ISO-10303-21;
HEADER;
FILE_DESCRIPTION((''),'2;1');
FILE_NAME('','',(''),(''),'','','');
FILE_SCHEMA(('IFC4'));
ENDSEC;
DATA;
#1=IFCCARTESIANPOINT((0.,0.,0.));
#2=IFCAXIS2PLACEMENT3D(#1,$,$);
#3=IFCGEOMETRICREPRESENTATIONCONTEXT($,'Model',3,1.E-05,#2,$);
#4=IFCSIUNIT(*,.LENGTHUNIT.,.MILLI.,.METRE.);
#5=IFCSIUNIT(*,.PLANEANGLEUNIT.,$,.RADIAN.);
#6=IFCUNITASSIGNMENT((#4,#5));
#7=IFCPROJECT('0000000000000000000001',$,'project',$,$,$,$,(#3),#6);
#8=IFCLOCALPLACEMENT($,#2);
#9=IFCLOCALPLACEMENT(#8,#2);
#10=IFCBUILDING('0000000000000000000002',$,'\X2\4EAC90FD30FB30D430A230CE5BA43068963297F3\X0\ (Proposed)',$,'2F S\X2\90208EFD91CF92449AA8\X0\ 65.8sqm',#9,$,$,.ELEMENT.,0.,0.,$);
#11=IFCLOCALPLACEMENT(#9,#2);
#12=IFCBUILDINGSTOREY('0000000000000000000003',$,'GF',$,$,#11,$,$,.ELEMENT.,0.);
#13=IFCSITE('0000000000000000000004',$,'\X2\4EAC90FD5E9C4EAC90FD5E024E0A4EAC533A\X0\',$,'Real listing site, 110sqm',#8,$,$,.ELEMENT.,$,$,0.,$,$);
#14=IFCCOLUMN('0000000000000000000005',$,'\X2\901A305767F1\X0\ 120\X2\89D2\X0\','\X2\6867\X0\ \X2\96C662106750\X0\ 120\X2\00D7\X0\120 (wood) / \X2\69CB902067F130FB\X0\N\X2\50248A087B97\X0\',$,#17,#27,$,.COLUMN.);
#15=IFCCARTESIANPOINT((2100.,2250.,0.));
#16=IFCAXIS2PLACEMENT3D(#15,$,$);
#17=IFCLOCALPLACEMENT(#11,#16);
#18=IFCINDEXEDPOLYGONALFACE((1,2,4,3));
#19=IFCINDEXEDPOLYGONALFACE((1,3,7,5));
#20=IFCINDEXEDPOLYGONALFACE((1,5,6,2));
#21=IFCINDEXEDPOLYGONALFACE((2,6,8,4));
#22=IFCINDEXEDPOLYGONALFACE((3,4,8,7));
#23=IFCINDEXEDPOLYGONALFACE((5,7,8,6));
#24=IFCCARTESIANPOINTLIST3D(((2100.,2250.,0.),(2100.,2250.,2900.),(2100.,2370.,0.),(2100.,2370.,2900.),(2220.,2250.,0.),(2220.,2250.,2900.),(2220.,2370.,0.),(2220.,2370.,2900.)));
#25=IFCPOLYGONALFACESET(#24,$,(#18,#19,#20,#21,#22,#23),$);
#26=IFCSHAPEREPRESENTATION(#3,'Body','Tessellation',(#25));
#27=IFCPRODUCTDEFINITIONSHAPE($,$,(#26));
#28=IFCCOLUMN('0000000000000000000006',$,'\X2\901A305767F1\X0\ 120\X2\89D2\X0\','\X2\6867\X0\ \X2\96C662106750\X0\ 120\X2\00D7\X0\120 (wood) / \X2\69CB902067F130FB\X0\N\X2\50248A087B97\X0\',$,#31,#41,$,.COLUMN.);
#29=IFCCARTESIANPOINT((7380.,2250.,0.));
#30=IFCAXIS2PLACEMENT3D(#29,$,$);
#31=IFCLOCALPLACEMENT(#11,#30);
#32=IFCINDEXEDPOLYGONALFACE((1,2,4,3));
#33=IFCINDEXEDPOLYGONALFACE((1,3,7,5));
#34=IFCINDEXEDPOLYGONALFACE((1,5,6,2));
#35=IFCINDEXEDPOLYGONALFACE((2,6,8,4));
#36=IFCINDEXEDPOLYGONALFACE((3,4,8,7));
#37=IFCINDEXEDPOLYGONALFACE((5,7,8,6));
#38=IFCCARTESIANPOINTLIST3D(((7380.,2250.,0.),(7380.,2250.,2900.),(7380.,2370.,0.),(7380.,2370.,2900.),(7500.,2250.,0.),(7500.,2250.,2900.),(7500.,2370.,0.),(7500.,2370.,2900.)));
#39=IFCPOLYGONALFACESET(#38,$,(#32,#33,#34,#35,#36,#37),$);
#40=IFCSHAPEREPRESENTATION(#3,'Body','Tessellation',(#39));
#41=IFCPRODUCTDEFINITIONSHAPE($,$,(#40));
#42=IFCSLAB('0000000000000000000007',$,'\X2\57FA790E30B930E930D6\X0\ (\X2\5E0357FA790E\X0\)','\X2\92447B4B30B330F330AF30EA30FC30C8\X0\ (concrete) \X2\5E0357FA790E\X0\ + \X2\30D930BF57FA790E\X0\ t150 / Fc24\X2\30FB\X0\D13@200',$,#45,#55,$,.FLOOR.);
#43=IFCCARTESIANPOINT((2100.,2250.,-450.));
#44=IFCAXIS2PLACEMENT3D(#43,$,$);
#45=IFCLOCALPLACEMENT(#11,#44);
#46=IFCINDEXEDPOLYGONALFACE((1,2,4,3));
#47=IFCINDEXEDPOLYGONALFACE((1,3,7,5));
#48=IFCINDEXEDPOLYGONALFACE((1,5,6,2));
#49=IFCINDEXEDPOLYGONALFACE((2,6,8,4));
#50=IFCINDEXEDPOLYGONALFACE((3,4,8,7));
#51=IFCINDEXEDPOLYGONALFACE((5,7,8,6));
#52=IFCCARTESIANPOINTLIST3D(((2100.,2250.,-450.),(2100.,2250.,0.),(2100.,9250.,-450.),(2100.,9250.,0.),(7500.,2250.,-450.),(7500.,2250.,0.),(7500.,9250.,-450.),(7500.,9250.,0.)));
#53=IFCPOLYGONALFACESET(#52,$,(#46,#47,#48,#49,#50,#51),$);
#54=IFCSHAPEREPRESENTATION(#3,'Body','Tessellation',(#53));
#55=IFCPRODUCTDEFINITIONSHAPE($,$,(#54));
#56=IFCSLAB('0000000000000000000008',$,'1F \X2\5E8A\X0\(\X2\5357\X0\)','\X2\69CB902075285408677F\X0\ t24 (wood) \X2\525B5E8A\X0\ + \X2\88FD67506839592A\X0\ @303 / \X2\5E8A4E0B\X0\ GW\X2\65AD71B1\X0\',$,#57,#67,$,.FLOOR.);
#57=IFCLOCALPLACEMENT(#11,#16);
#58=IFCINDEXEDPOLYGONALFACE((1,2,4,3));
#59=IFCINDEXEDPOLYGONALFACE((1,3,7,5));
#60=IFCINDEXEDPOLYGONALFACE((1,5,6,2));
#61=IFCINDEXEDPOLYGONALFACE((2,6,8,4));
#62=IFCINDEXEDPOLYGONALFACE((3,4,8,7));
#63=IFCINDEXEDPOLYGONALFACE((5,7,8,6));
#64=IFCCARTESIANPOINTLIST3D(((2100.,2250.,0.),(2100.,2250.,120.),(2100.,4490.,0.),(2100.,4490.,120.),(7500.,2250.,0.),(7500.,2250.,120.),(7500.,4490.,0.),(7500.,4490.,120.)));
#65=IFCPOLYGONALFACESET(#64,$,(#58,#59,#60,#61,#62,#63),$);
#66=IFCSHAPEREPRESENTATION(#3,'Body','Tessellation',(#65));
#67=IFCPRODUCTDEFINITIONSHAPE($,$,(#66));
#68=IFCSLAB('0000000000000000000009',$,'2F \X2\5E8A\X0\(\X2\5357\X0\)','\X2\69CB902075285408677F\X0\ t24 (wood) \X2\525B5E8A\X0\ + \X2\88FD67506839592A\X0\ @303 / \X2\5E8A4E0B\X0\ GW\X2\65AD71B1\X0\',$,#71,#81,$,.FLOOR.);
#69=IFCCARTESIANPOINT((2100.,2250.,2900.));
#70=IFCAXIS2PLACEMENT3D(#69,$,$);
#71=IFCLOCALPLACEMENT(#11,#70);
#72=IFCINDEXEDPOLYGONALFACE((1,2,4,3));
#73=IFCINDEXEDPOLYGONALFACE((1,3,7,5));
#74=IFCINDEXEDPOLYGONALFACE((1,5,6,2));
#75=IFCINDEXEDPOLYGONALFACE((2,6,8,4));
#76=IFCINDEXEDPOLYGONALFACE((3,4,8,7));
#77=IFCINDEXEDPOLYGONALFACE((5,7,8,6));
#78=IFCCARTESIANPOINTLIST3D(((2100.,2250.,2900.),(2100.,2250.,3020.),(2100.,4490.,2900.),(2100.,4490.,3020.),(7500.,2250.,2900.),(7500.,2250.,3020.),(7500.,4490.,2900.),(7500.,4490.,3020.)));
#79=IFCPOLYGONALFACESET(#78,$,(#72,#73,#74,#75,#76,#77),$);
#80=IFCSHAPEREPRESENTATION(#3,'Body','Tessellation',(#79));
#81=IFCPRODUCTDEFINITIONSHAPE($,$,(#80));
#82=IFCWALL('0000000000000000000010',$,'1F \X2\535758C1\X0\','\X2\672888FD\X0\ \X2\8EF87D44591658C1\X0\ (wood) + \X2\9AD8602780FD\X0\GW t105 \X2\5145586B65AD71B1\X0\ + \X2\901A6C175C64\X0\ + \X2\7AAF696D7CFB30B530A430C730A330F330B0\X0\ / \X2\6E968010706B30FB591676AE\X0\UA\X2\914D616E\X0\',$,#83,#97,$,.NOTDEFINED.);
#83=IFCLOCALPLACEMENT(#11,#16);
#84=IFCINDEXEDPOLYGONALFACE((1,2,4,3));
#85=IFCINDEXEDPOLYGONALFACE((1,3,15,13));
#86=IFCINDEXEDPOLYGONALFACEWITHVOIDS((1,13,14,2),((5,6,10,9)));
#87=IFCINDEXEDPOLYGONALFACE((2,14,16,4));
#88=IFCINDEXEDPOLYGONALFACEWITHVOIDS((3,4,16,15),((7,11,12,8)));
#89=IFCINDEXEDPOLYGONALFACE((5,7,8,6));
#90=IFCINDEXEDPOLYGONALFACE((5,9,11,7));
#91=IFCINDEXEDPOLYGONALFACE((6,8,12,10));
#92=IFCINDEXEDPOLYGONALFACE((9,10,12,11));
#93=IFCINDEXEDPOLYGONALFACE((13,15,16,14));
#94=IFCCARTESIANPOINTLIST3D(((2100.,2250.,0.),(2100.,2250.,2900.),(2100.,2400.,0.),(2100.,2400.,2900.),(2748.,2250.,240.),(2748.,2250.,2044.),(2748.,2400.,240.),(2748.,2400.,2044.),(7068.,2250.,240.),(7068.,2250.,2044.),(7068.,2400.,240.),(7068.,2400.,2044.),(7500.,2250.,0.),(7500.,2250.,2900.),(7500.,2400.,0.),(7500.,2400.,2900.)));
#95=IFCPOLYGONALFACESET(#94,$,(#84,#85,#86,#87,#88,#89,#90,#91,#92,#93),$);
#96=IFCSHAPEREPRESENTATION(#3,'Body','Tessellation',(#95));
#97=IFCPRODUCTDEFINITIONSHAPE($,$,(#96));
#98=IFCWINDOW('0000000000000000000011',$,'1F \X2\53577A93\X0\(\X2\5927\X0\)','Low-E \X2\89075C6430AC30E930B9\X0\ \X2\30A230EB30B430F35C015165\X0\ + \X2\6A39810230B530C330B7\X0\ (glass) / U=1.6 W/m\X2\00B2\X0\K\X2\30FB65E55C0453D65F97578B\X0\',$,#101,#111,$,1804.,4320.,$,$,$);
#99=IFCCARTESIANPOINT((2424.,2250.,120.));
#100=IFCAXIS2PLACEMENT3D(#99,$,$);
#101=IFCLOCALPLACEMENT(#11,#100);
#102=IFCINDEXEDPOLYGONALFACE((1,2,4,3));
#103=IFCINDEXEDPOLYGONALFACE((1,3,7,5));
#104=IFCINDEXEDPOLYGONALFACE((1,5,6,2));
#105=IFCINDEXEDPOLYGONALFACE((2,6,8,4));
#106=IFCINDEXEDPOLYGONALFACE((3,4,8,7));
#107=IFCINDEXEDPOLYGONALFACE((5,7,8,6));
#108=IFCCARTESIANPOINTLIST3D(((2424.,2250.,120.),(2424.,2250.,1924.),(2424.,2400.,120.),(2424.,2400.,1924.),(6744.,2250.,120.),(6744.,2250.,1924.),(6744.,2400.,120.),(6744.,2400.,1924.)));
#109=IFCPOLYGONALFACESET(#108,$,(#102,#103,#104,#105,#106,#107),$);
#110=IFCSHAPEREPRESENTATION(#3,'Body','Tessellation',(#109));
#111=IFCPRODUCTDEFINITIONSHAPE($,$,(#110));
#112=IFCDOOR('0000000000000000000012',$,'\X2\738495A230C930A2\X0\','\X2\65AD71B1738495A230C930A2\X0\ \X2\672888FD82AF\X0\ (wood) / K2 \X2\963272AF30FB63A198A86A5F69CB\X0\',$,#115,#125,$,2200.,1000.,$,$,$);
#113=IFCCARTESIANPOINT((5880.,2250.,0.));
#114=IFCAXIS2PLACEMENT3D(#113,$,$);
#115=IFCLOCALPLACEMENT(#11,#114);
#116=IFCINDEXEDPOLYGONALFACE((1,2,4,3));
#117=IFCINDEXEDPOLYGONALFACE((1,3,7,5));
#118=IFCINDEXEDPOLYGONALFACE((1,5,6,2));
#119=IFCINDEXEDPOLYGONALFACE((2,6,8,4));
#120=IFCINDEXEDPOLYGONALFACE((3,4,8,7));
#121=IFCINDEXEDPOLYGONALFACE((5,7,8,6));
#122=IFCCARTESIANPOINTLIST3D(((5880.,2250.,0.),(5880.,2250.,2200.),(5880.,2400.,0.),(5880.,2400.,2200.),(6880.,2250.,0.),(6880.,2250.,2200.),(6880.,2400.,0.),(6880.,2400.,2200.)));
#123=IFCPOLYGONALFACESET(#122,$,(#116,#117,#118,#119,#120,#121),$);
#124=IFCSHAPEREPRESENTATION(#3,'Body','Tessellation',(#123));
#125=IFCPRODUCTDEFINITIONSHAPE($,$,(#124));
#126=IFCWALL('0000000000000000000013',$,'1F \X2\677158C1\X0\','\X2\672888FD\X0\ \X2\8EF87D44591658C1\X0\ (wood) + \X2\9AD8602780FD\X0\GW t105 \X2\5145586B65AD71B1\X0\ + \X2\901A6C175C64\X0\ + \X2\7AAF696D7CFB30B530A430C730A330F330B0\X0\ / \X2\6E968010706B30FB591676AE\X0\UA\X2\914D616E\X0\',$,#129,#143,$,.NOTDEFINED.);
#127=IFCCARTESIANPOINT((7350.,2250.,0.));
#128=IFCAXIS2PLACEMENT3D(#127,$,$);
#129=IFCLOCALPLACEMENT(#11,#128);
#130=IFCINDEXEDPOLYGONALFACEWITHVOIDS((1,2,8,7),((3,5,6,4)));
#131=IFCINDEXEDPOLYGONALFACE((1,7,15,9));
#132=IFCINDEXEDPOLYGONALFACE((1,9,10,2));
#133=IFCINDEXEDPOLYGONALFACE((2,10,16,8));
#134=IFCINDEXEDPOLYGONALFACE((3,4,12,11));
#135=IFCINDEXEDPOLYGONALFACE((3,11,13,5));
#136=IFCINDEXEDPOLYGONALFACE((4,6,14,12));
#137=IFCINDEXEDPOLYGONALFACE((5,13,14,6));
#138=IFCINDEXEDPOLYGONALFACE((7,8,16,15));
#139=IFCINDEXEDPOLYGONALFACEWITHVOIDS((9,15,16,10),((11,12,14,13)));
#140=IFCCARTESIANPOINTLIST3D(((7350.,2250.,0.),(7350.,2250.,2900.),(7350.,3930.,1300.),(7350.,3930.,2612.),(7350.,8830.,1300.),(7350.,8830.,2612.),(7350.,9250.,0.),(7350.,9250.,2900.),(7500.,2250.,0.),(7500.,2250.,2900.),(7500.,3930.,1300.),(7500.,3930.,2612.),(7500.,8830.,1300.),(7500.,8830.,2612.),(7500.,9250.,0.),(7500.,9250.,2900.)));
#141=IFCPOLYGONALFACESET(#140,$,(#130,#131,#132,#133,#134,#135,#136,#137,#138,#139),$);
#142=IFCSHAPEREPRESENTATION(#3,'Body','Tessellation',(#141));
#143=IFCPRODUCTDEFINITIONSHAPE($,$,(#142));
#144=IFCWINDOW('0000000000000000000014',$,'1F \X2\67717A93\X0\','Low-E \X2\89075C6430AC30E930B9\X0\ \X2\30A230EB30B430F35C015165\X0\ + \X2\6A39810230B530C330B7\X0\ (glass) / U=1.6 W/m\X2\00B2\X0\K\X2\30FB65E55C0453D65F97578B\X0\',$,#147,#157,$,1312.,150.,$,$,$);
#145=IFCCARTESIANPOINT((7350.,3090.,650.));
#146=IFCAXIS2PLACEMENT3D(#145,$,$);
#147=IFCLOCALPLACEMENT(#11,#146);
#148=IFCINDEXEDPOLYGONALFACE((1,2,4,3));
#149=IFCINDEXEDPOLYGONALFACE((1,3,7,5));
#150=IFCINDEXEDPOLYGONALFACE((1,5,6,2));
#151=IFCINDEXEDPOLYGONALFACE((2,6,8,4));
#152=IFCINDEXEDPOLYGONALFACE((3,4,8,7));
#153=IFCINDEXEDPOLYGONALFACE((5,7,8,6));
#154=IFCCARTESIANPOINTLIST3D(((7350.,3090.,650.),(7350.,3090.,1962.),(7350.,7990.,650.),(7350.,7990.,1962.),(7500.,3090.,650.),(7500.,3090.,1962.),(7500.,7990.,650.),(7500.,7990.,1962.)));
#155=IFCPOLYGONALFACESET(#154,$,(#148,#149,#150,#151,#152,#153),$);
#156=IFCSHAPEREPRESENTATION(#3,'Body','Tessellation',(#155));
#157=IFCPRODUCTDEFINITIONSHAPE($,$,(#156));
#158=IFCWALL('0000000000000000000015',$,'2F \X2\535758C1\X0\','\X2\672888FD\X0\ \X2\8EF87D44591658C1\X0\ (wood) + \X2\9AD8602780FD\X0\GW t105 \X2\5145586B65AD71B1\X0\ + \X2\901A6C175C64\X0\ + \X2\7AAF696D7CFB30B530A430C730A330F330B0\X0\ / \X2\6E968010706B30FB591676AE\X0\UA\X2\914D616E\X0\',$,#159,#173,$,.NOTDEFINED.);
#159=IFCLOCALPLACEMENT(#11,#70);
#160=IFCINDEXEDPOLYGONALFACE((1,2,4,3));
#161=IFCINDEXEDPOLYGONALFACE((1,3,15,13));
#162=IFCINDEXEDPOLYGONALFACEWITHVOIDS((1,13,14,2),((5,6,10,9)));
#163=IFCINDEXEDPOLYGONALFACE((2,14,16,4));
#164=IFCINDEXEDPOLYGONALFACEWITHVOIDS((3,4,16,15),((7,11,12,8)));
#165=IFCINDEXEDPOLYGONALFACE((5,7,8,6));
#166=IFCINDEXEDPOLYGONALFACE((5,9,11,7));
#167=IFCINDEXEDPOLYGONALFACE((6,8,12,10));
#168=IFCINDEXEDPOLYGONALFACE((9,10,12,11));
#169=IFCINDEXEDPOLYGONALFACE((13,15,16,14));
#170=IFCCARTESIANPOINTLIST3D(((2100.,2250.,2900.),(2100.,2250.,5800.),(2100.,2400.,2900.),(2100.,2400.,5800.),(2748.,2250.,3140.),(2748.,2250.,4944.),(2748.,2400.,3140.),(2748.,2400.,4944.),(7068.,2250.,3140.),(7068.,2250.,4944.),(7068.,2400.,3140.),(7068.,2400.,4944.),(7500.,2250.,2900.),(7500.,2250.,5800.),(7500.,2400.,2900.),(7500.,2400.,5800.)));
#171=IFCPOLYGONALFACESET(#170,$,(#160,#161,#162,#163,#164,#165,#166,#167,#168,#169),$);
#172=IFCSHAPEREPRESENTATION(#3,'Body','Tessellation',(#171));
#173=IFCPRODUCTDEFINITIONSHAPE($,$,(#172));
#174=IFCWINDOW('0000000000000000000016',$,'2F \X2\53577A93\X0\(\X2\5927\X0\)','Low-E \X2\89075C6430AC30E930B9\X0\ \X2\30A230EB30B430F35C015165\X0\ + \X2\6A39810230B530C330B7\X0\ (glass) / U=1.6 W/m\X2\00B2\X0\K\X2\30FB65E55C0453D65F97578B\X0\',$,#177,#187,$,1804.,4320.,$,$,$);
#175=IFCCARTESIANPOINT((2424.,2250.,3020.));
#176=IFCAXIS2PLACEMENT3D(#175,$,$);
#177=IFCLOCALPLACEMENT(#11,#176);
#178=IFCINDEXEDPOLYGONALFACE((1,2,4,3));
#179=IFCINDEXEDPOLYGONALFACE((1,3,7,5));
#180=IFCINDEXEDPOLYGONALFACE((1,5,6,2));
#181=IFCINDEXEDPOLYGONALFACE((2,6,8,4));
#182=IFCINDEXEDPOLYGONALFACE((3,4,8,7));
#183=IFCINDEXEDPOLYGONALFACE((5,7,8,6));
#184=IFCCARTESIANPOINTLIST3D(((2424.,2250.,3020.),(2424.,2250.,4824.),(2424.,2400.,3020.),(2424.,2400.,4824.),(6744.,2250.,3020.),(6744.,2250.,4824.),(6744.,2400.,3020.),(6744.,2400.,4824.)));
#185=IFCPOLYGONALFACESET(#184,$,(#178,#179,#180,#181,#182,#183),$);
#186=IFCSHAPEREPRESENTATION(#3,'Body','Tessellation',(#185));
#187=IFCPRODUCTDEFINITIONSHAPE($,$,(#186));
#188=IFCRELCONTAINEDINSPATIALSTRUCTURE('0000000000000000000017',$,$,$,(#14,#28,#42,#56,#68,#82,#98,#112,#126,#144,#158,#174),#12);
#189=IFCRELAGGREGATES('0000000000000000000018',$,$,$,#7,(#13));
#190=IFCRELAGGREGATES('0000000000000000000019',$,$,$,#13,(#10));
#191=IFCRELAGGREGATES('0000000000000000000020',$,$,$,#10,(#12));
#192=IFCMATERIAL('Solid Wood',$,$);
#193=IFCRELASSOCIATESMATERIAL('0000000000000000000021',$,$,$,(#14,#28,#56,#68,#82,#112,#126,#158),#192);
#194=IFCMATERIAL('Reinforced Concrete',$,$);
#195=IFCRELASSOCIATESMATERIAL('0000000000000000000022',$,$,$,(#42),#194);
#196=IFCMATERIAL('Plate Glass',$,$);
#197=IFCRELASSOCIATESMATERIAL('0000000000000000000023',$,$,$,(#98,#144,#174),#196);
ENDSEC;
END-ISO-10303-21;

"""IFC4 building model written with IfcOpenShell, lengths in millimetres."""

from ifc_helpers import new_model, si_unit, frame, frame_2d, origin, place, context, project, spatial, rectangle, extrude, material, element, fill, save


model = new_model("IFC4")

# Units and contexts
model_context = context("Model", 3, precision=1e-05, world=origin())
ifc_project = project(units=[si_unit("LENGTHUNIT", "METRE", prefix="MILLI"), si_unit("PLANEANGLEUNIT", "RADIAN")], contexts=[model_context])

# Site, building, storey
site_placement = place(None, origin())
site = spatial("IfcSite", under=ifc_project, at=site_placement, Name="京都府京都市上京区", ObjectType="Real listing site, 110sqm", CompositionType="ELEMENT", RefElevation=0.0)
building_placement = place(site_placement, origin())
building = spatial("IfcBuilding", under=site, at=building_placement, Name="京都・ピアノ室と防音 (Proposed)", ObjectType="2F S造軽量鉄骨 65.8sqm", CompositionType="ELEMENT", ElevationOfRefHeight=0.0, ElevationOfTerrain=0.0)
storey_placement = place(building_placement, origin())
storey = spatial("IfcBuildingStorey", under=building, at=storey_placement, Name="GF", CompositionType="ELEMENT", Elevation=0.0)

# Columns
ifc_material_1 = material(Name="Solid Wood")
column_1_placement = place(storey_placement, frame((2100.0, 2250.0, 0.0)))
element("IfcColumn", 1, at=column_1_placement, inside=storey, material=ifc_material_1, Name="通し柱 120角", Description="桧 集成材 120×120 (wood) / 構造柱・N値計算", PredefinedType="COLUMN", context=model_context, shape_type="SweptSolid", body=[
    extrude(rectangle(XDim=120.0, YDim=120.0, at=frame_2d((60.0, 60.0))), frame((2100.0, 2250.0, 0.0)), (0.0, 0.0, 1.0), 2900.0),
])
column_2_placement = place(storey_placement, frame((7380.0, 2250.0, 0.0)))
element("IfcColumn", 2, at=column_2_placement, inside=storey, material=ifc_material_1, Name="通し柱 120角", Description="桧 集成材 120×120 (wood) / 構造柱・N値計算", PredefinedType="COLUMN", context=model_context, shape_type="SweptSolid", body=[
    extrude(rectangle(XDim=120.0, YDim=120.0, at=frame_2d((60.0, 60.0))), frame((7380.0, 2250.0, 0.0)), (0.0, 0.0, 1.0), 2900.0),
])

# Slabs
ifc_material_2 = material(Name="Reinforced Concrete")
slab_1_placement = place(storey_placement, frame((2100.0, 2250.0, -450.0)))
element("IfcSlab", 3, at=slab_1_placement, inside=storey, material=ifc_material_2, Name="基礎スラブ (布基礎)", Description="鉄筋コンクリート (concrete) 布基礎 + ベタ基礎 t150 / Fc24・D13@200", PredefinedType="FLOOR", context=model_context, shape_type="SweptSolid", body=[
    extrude(rectangle(XDim=5400.0, YDim=7000.0, at=frame_2d((2700.0, 3500.0))), frame((2100.0, 2250.0, -450.0)), (0.0, 0.0, 1.0), 450.0),
])
slab_2_placement = place(storey_placement, frame((2100.0, 2250.0, 0.0)))
element("IfcSlab", 4, at=slab_2_placement, inside=storey, material=ifc_material_1, Name="1F 床(南)", Description="構造用合板 t24 (wood) 剛床 + 製材根太 @303 / 床下 GW断熱", PredefinedType="FLOOR", context=model_context, shape_type="SweptSolid", body=[
    extrude(rectangle(XDim=5400.0, YDim=2240.0, at=frame_2d((2700.0, 1120.0))), frame((2100.0, 2250.0, 0.0)), (0.0, 0.0, 1.0), 120.0),
])
slab_3_placement = place(storey_placement, frame((2100.0, 2250.0, 2900.0)))
element("IfcSlab", 5, at=slab_3_placement, inside=storey, material=ifc_material_1, Name="2F 床(南)", Description="構造用合板 t24 (wood) 剛床 + 製材根太 @303 / 床下 GW断熱", PredefinedType="FLOOR", context=model_context, shape_type="SweptSolid", body=[
    extrude(rectangle(XDim=5400.0, YDim=2240.0, at=frame_2d((2700.0, 1120.0))), frame((2100.0, 2250.0, 2900.0)), (0.0, 0.0, 1.0), 120.0),
])

# Wall, openings, window, door
wall_1_placement = place(storey_placement, frame((2100.0, 2250.0, 0.0)))
wall_1 = element("IfcWall", 6, at=wall_1_placement, inside=storey, material=ifc_material_1, Name="1F 南壁", Description="木製 軸組外壁 (wood) + 高性能GW t105 充填断熱 + 通気層 + 窯業系サイディング / 準耐火・外皮UA配慮", PredefinedType="NOTDEFINED", context=model_context, shape_type="SweptSolid", body=[
    extrude(rectangle(XDim=5400.0, YDim=150.0, at=frame_2d((2700.0, 75.0))), frame((2100.0, 2250.0, 0.0)), (0.0, 0.0, 1.0), 2900.0),
])
opening_1_placement = place(storey_placement, frame((2424.0, 2250.0, 120.0)))
opening_1 = element("IfcOpeningElement", 7, at=opening_1_placement, cuts=wall_1, PredefinedType="NOTDEFINED", context=model_context, shape_type="SweptSolid", body=[
    extrude(rectangle(XDim=4320.0, YDim=150.0, at=frame_2d((2160.0, 75.0))), frame((2424.0, 2250.0, 120.0)), (0.0, 0.0, 1.0), 1804.0),
])
opening_2_placement = place(storey_placement, frame((5880.0, 2250.0, 0.0)))
opening_2 = element("IfcOpeningElement", 8, at=opening_2_placement, cuts=wall_1, PredefinedType="NOTDEFINED", context=model_context, shape_type="SweptSolid", body=[
    extrude(rectangle(XDim=1000.0, YDim=150.0, at=frame_2d((500.0, 75.0))), frame((5880.0, 2250.0, 0.0)), (0.0, 0.0, 1.0), 2200.0),
])
ifc_material_3 = material(Name="Plate Glass")
window_1_placement = place(storey_placement, frame((2424.0, 2250.0, 120.0)))
window_1 = element("IfcWindow", 9, at=window_1_placement, inside=storey, material=ifc_material_3, Name="1F 南窓(大)", Description="Low-E 複層ガラス アルゴン封入 + 樹脂サッシ (glass) / U=1.6 W/m²K・日射取得型", OverallHeight=1804.0, OverallWidth=4320.0, context=model_context, shape_type="SweptSolid", body=[
    extrude(rectangle(XDim=4320.0, YDim=150.0, at=frame_2d((2160.0, 75.0))), frame((2424.0, 2250.0, 120.0)), (0.0, 0.0, 1.0), 1804.0),
])
fill(opening_1, window_1)
door_placement = place(storey_placement, frame((5880.0, 2250.0, 0.0)))
door = element("IfcDoor", 10, at=door_placement, inside=storey, material=ifc_material_1, Name="玄関ドア", Description="断熱玄関ドア 木製芯 (wood) / K2 防犯・採風機構", OverallHeight=2200.0, OverallWidth=1000.0, context=model_context, shape_type="SweptSolid", body=[
    extrude(rectangle(XDim=1000.0, YDim=150.0, at=frame_2d((500.0, 75.0))), frame((5880.0, 2250.0, 0.0)), (0.0, 0.0, 1.0), 2200.0),
])
fill(opening_2, door)

# Walls, openings, windows
wall_2_placement = place(storey_placement, frame((7350.0, 2250.0, 0.0)))
wall_2 = element("IfcWall", 11, at=wall_2_placement, inside=storey, material=ifc_material_1, Name="1F 東壁", Description="木製 軸組外壁 (wood) + 高性能GW t105 充填断熱 + 通気層 + 窯業系サイディング / 準耐火・外皮UA配慮", PredefinedType="NOTDEFINED", context=model_context, shape_type="SweptSolid", body=[
    extrude(rectangle(XDim=150.0, YDim=7000.0, at=frame_2d((75.0, 3500.0))), frame((7350.0, 2250.0, 0.0)), (0.0, 0.0, 1.0), 2900.0),
])
opening_3_placement = place(storey_placement, frame((7350.0, 3090.0, 650.0)))
opening_3 = element("IfcOpeningElement", 12, at=opening_3_placement, cuts=wall_2, PredefinedType="NOTDEFINED", context=model_context, shape_type="SweptSolid", body=[
    extrude(rectangle(XDim=150.0, YDim=4900.0, at=frame_2d((75.0, 2450.0))), frame((7350.0, 3090.0, 650.0)), (0.0, 0.0, 1.0), 1312.0),
])
window_2_placement = place(storey_placement, frame((7350.0, 3090.0, 650.0)))
window_2 = element("IfcWindow", 13, at=window_2_placement, inside=storey, material=ifc_material_3, Name="1F 東窓", Description="Low-E 複層ガラス アルゴン封入 + 樹脂サッシ (glass) / U=1.6 W/m²K・日射取得型", OverallHeight=1312.0, OverallWidth=150.0, context=model_context, shape_type="SweptSolid", body=[
    extrude(rectangle(XDim=150.0, YDim=4900.0, at=frame_2d((75.0, 2450.0))), frame((7350.0, 3090.0, 650.0)), (0.0, 0.0, 1.0), 1312.0),
])
fill(opening_3, window_2)
wall_3_placement = place(storey_placement, frame((2100.0, 2250.0, 2900.0)))
wall_3 = element("IfcWall", 14, at=wall_3_placement, inside=storey, material=ifc_material_1, Name="2F 南壁", Description="木製 軸組外壁 (wood) + 高性能GW t105 充填断熱 + 通気層 + 窯業系サイディング / 準耐火・外皮UA配慮", PredefinedType="NOTDEFINED", context=model_context, shape_type="SweptSolid", body=[
    extrude(rectangle(XDim=5400.0, YDim=150.0, at=frame_2d((2700.0, 75.0))), frame((2100.0, 2250.0, 2900.0)), (0.0, 0.0, 1.0), 2900.0),
])
opening_4_placement = place(storey_placement, frame((2424.0, 2250.0, 3020.0)))
opening_4 = element("IfcOpeningElement", 15, at=opening_4_placement, cuts=wall_3, PredefinedType="NOTDEFINED", context=model_context, shape_type="SweptSolid", body=[
    extrude(rectangle(XDim=4320.0, YDim=150.0, at=frame_2d((2160.0, 75.0))), frame((2424.0, 2250.0, 3020.0)), (0.0, 0.0, 1.0), 1804.0),
])
window_3_placement = place(storey_placement, frame((2424.0, 2250.0, 3020.0)))
window_3 = element("IfcWindow", 16, at=window_3_placement, inside=storey, material=ifc_material_3, Name="2F 南窓(大)", Description="Low-E 複層ガラス アルゴン封入 + 樹脂サッシ (glass) / U=1.6 W/m²K・日射取得型", OverallHeight=1804.0, OverallWidth=4320.0, context=model_context, shape_type="SweptSolid", body=[
    extrude(rectangle(XDim=4320.0, YDim=150.0, at=frame_2d((2160.0, 75.0))), frame((2424.0, 2250.0, 3020.0)), (0.0, 0.0, 1.0), 1804.0),
])
fill(opening_4, window_3)

save(model, "model.ifc")
